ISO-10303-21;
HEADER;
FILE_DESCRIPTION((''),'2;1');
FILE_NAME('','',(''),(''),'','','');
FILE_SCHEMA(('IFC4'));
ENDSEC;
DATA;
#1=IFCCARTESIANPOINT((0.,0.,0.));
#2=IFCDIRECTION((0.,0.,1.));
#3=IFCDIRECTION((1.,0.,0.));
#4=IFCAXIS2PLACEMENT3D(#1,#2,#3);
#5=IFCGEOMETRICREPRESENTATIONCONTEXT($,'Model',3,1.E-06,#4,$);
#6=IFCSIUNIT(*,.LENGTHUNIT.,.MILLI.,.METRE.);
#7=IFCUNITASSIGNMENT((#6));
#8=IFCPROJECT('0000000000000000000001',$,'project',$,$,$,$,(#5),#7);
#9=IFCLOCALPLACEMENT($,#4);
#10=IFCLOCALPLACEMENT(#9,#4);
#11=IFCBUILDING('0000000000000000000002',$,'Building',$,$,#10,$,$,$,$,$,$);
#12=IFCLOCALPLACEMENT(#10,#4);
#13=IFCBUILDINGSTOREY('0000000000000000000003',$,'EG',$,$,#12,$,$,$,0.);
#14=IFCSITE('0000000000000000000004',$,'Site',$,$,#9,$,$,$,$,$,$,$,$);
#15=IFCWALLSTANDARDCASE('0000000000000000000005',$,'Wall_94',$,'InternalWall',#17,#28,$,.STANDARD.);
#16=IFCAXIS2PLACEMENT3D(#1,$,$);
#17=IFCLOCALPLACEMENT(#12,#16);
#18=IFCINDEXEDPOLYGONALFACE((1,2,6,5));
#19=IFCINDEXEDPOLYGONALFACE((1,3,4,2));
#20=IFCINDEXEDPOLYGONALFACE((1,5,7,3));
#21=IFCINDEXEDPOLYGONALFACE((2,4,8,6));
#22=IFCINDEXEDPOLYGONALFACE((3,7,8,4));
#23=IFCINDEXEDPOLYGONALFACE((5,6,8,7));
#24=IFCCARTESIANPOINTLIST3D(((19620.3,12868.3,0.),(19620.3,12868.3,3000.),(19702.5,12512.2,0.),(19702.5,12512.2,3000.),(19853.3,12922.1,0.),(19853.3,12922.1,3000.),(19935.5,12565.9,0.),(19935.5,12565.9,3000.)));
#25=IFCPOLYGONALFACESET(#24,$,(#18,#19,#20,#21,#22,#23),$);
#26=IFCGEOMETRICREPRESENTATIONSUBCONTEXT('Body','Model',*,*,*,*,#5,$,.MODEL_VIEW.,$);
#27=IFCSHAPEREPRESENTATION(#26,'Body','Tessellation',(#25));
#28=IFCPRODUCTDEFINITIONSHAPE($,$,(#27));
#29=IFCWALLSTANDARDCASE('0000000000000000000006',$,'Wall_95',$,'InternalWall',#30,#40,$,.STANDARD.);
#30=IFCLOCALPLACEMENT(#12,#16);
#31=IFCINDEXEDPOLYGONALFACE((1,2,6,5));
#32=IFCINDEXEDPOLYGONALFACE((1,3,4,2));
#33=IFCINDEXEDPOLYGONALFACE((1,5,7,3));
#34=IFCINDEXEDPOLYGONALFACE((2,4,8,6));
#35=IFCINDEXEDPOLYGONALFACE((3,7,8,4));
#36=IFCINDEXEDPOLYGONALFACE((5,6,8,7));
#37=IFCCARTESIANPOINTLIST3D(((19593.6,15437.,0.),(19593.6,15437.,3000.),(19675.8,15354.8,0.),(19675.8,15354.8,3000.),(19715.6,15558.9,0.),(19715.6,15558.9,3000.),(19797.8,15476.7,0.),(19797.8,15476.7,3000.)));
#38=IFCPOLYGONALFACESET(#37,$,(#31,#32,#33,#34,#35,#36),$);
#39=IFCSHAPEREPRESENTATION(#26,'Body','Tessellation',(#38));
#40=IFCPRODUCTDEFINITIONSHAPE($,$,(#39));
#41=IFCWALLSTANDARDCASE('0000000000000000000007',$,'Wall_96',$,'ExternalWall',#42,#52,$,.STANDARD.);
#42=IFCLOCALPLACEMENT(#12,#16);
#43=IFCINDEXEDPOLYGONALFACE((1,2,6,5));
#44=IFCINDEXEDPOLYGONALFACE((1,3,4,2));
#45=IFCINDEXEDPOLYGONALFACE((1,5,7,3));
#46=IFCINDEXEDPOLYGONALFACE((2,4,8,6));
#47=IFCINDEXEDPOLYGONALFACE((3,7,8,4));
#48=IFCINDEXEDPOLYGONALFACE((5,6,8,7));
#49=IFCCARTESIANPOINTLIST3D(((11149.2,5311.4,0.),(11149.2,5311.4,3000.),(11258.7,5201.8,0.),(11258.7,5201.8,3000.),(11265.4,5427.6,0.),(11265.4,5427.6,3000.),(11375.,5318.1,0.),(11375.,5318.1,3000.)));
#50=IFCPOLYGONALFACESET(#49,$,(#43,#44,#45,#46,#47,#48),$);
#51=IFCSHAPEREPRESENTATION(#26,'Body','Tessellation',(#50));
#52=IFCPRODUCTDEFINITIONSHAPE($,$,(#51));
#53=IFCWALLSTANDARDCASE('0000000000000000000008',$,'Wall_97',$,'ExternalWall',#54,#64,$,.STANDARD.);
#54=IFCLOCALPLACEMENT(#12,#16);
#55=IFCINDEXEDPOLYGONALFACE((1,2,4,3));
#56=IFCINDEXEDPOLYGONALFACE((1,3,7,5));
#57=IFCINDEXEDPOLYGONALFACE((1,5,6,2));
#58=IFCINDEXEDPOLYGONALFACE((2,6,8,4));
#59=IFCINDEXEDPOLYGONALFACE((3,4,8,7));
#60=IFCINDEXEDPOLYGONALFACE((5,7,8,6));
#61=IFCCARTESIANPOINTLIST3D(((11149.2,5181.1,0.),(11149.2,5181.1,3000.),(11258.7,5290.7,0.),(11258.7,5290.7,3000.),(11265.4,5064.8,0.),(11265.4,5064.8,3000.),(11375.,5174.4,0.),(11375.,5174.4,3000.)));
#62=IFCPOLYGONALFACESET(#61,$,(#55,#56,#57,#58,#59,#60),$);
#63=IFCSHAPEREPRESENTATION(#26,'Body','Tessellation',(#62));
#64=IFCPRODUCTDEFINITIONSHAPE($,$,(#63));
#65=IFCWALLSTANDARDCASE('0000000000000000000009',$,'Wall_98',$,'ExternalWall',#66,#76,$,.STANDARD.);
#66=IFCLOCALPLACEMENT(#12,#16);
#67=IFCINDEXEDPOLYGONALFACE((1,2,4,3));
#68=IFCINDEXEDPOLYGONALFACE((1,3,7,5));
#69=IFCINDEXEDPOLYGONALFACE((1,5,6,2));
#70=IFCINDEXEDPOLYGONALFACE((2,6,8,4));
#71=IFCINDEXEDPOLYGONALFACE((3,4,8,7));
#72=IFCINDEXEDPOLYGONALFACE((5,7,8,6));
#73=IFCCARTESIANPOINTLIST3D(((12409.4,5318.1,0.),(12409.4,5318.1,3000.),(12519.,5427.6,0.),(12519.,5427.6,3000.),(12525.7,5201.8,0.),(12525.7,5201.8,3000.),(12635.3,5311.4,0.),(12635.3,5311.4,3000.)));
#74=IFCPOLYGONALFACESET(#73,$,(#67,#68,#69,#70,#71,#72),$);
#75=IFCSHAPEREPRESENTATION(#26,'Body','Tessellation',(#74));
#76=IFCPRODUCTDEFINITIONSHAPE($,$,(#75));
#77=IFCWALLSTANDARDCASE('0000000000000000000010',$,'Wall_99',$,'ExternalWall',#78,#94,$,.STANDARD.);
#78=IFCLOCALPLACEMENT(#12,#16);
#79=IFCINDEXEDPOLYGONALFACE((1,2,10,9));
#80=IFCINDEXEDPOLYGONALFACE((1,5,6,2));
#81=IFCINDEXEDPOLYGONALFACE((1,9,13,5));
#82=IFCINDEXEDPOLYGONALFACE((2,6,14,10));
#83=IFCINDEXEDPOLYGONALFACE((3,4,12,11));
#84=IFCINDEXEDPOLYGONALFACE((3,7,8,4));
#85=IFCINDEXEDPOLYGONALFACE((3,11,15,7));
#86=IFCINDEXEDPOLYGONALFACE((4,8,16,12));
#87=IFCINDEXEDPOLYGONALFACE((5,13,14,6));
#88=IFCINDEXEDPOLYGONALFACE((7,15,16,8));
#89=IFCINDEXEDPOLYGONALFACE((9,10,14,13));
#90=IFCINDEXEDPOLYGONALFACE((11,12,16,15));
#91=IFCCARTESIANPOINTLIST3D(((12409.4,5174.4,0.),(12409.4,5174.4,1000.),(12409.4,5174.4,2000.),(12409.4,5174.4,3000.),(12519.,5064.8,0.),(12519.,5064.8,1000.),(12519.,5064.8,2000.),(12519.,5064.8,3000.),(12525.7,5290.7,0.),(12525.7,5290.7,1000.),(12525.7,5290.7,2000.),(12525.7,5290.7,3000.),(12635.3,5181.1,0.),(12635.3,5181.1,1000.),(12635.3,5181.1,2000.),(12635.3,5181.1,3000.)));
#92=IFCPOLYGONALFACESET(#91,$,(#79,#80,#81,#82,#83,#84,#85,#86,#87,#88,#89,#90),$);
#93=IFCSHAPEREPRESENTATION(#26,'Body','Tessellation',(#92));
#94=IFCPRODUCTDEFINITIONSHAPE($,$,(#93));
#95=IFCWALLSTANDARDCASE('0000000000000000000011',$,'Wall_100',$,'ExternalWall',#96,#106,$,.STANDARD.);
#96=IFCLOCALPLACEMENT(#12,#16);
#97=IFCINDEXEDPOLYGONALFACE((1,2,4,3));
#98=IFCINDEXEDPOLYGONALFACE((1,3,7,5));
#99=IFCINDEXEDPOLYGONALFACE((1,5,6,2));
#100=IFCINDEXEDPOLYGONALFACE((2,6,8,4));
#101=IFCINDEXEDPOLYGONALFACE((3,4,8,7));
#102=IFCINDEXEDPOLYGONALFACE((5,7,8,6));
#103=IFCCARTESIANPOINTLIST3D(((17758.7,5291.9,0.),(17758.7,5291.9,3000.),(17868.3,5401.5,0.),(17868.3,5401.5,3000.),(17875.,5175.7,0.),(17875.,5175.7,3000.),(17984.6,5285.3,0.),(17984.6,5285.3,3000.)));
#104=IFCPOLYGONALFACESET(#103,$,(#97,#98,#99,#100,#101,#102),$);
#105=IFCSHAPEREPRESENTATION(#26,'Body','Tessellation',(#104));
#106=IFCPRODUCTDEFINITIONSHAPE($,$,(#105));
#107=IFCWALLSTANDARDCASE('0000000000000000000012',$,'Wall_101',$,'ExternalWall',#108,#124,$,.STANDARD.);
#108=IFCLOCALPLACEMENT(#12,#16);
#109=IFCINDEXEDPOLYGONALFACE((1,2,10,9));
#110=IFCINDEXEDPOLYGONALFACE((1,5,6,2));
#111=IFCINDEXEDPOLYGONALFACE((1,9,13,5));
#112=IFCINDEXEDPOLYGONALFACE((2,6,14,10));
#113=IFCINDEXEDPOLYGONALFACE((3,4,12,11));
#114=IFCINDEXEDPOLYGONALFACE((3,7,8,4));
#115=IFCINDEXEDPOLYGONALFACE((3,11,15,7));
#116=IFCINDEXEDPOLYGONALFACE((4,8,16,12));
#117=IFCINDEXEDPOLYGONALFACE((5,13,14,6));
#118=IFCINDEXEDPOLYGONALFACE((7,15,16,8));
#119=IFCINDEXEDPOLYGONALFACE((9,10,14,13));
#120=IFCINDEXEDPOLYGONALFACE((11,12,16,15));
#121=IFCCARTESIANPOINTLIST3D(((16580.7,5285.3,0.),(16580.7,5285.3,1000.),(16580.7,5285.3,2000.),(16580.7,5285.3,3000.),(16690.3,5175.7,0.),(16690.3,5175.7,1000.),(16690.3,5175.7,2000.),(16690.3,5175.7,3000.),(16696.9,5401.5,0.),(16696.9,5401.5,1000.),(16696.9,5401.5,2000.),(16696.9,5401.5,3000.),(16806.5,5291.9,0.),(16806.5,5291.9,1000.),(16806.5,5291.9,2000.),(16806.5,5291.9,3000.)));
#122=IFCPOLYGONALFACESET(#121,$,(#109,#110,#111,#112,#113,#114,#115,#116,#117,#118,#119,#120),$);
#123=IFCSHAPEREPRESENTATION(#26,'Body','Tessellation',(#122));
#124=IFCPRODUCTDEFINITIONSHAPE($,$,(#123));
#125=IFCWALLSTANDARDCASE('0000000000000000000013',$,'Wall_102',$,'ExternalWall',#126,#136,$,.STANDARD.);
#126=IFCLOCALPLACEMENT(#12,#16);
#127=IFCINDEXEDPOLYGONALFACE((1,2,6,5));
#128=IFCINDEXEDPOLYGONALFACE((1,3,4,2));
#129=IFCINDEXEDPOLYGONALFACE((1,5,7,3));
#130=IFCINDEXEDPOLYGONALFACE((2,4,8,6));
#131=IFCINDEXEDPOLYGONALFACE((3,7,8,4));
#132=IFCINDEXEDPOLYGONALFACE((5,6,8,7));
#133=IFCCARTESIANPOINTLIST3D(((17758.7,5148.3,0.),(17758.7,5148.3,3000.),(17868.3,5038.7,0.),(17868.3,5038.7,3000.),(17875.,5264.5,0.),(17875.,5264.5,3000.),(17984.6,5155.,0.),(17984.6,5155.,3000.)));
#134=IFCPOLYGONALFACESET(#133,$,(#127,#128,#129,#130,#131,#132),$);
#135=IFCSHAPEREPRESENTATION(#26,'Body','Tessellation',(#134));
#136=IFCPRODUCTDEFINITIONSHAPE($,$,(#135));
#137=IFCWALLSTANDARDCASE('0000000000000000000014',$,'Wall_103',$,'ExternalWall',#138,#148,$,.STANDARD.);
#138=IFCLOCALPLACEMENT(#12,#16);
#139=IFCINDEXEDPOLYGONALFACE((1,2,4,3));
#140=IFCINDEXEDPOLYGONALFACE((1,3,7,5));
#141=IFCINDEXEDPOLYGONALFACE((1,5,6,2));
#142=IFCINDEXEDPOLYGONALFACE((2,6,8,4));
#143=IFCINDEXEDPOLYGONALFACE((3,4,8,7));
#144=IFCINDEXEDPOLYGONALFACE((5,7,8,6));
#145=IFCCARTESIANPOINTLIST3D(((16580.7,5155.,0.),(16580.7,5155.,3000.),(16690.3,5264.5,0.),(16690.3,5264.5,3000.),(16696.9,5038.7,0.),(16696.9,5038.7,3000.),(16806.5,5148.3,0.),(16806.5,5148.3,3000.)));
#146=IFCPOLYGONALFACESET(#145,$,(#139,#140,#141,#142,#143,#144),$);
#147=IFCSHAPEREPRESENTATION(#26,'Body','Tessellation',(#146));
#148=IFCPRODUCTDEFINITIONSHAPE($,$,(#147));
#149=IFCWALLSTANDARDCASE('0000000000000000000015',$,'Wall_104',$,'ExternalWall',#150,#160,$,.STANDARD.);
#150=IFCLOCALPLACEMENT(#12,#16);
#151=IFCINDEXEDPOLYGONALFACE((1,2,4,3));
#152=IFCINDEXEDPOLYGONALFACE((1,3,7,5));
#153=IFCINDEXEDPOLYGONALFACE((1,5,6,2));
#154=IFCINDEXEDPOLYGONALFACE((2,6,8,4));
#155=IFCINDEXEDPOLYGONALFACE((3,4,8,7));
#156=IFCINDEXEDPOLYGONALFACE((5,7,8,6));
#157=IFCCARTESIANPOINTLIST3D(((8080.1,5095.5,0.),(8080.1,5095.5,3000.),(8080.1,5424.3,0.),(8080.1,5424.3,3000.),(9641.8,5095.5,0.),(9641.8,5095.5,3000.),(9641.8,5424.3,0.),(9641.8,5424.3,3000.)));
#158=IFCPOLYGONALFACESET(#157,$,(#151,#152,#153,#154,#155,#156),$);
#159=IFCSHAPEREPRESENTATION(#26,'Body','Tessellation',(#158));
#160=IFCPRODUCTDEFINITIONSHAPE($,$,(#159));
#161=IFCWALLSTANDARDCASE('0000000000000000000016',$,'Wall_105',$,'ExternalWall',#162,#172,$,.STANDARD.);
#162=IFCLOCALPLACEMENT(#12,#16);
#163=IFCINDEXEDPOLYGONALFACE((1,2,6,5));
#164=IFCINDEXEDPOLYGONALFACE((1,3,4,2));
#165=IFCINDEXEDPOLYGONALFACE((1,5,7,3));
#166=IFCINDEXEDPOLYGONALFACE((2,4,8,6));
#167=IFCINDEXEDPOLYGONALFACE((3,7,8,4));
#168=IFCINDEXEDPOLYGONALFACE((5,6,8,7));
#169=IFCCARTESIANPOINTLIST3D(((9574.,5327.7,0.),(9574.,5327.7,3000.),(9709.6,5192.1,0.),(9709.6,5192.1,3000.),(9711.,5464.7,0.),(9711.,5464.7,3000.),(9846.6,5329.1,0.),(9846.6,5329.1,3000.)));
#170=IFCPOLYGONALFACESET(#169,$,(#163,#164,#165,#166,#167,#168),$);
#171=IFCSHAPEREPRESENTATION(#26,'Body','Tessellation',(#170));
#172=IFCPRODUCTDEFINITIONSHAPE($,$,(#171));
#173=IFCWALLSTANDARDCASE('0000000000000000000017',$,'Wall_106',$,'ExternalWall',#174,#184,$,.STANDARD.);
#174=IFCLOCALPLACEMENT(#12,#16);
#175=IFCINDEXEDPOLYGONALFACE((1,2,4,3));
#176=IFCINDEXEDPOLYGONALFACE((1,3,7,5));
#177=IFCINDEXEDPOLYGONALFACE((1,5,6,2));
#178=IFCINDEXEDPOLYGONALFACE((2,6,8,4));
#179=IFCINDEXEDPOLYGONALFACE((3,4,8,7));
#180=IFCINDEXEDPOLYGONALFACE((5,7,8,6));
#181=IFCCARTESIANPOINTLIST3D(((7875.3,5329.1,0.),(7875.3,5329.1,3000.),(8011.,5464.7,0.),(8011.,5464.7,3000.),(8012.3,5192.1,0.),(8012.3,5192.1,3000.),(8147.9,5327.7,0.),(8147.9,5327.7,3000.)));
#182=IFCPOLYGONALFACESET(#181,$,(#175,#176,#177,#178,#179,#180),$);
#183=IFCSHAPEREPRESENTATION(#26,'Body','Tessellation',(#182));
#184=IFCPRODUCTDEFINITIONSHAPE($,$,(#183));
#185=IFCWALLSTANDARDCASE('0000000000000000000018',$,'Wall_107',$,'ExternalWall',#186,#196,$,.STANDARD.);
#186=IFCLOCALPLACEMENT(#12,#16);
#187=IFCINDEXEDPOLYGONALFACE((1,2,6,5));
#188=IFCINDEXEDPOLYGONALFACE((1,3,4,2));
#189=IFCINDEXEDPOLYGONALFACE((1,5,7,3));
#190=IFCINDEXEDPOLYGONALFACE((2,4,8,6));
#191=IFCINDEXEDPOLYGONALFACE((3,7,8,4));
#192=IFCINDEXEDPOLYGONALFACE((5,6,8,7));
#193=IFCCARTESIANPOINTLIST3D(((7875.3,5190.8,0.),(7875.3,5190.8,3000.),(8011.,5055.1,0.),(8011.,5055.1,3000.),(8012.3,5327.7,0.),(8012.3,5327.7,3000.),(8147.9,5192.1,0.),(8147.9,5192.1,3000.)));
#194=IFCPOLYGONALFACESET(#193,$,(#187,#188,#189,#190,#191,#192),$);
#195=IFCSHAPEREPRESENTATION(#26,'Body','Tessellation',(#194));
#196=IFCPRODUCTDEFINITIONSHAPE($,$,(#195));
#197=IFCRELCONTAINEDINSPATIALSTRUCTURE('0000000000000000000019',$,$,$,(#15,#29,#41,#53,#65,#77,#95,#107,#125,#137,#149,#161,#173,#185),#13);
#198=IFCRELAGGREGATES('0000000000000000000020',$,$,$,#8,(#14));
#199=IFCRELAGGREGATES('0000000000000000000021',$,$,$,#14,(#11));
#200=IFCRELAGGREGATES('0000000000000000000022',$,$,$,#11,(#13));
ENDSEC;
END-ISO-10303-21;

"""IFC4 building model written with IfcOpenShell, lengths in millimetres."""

from ifc_helpers import new_model, si_unit, frame, origin_with_axes, place, context, subcontext, project, spatial, rectangle, extrude, element, save


model = new_model("IFC4")

# Units and contexts
model_context = context("Model", 3, precision=1e-06, world=origin_with_axes())
body_context = subcontext(model_context, "Body", "Model", "MODEL_VIEW")
ifc_project = project(units=[si_unit("LENGTHUNIT", "METRE", prefix="MILLI")], contexts=[model_context])

# Site, building, storey
site_placement = place(None, origin_with_axes())
site = spatial("IfcSite", under=ifc_project, at=site_placement, Name="Site")
building_placement = place(site_placement, origin_with_axes())
building = spatial("IfcBuilding", under=site, at=building_placement, Name="Building")
storey_placement = place(building_placement, origin_with_axes())
storey = spatial("IfcBuildingStorey", under=building, at=storey_placement, Name="EG", Elevation=0.0)

# Walls
wall_1_placement = place(storey_placement, origin_with_axes())
element("IfcWallStandardCase", 1, at=wall_1_placement, inside=storey, Name="Wall_94", ObjectType="InternalWall", PredefinedType="STANDARD", context=body_context, shape_type="SweptSolid", body=[
    extrude(rectangle(XDim=365.5, YDim=239.1), frame((19777.9, 12717.1, 0.0), z_axis=(0.0, 0.0, 1.0), x_axis=(0.22486, -0.974391, 0.0)), (0.0, 0.0, 1.0), 3000.0),
])
wall_2_placement = place(storey_placement, origin_with_axes())
element("IfcWallStandardCase", 2, at=wall_2_placement, inside=storey, Name="Wall_95", ObjectType="InternalWall", PredefinedType="STANDARD", context=body_context, shape_type="SweptSolid", body=[
    extrude(rectangle(XDim=116.2, YDim=172.5), frame((19695.7, 15456.9, 0.0), z_axis=(0.0, 0.0, 1.0), x_axis=(-0.707107, 0.707107, 0.0)), (0.0, 0.0, 1.0), 3000.0),
])
wall_3_placement = place(storey_placement, origin_with_axes())
element("IfcWallStandardCase", 3, at=wall_3_placement, inside=storey, Name="Wall_96", ObjectType="ExternalWall", PredefinedType="STANDARD", context=body_context, shape_type="SweptSolid", body=[
    extrude(rectangle(XDim=155.0, YDim=164.4), frame((11262.1, 5314.7, 0.0), z_axis=(0.0, 0.0, 1.0), x_axis=(-0.707107, 0.707107, 0.0)), (0.0, 0.0, 1.0), 3000.0),
])
wall_4_placement = place(storey_placement, origin_with_axes())
element("IfcWallStandardCase", 4, at=wall_4_placement, inside=storey, Name="Wall_97", ObjectType="ExternalWall", PredefinedType="STANDARD", context=body_context, shape_type="SweptSolid", body=[
    extrude(rectangle(XDim=155.0, YDim=164.4), frame((11262.1, 5177.7, 0.0), z_axis=(0.0, 0.0, 1.0), x_axis=(-0.707107, -0.707107, 0.0)), (0.0, 0.0, 1.0), 3000.0),
])
wall_5_placement = place(storey_placement, origin_with_axes())
element("IfcWallStandardCase", 5, at=wall_5_placement, inside=storey, Name="Wall_98", ObjectType="ExternalWall", PredefinedType="STANDARD", context=body_context, shape_type="SweptSolid", body=[
    extrude(rectangle(XDim=155.0, YDim=164.4), frame((12522.3, 5314.7, 0.0), z_axis=(0.0, 0.0, 1.0), x_axis=(0.707107, 0.707107, 0.0)), (0.0, 0.0, 1.0), 3000.0),
])

# Wall, opening
wall_6_placement = place(storey_placement, origin_with_axes())
wall_6 = element("IfcWallStandardCase", 6, at=wall_6_placement, inside=storey, Name="Wall_99", ObjectType="ExternalWall", PredefinedType="STANDARD", context=body_context, shape_type="SweptSolid", body=[
    extrude(rectangle(XDim=155.0, YDim=164.4), frame((12522.3, 5177.7, 0.0), z_axis=(0.0, 0.0, 1.0), x_axis=(0.707107, -0.707107, 0.0)), (0.0, 0.0, 1.0), 3000.0),
])
opening_1_placement = place(wall_6_placement, origin_with_axes())
element("IfcOpeningElement", 7, at=opening_1_placement, inside=storey, cuts=wall_6, context=body_context, shape_type="SweptSolid", body=[
    extrude(rectangle(XDim=600.0, YDim=164.4), frame((12522.3, 5177.7, 1000.0), z_axis=(0.0, 0.0, 1.0), x_axis=(0.707107, -0.707107, 0.0)), (0.0, 0.0, 1.0), 1000.0),
])

# Wall
wall_7_placement = place(storey_placement, origin_with_axes())
element("IfcWallStandardCase", 8, at=wall_7_placement, inside=storey, Name="Wall_100", ObjectType="ExternalWall", PredefinedType="STANDARD", context=body_context, shape_type="SweptSolid", body=[
    extrude(rectangle(XDim=155.0, YDim=164.4), frame((17871.7, 5288.6, 0.0), z_axis=(0.0, 0.0, 1.0), x_axis=(0.707107, 0.707107, 0.0)), (0.0, 0.0, 1.0), 3000.0),
])

# Wall, opening
wall_8_placement = place(storey_placement, origin_with_axes())
wall_8 = element("IfcWallStandardCase", 9, at=wall_8_placement, inside=storey, Name="Wall_101", ObjectType="ExternalWall", PredefinedType="STANDARD", context=body_context, shape_type="SweptSolid", body=[
    extrude(rectangle(XDim=155.0, YDim=164.4), frame((16693.6, 5288.6, 0.0), z_axis=(0.0, 0.0, 1.0), x_axis=(-0.707107, 0.707107, 0.0)), (0.0, 0.0, 1.0), 3000.0),
])
opening_2_placement = place(wall_8_placement, origin_with_axes())
element("IfcOpeningElement", 10, at=opening_2_placement, inside=storey, cuts=wall_8, context=body_context, shape_type="SweptSolid", body=[
    extrude(rectangle(XDim=600.0, YDim=164.4), frame((16693.6, 5288.6, 1000.0), z_axis=(0.0, 0.0, 1.0), x_axis=(-0.707107, 0.707107, 0.0)), (0.0, 0.0, 1.0), 1000.0),
])

# Walls
wall_9_placement = place(storey_placement, origin_with_axes())
element("IfcWallStandardCase", 11, at=wall_9_placement, inside=storey, Name="Wall_102", ObjectType="ExternalWall", PredefinedType="STANDARD", context=body_context, shape_type="SweptSolid", body=[
    extrude(rectangle(XDim=155.0, YDim=164.4), frame((17871.7, 5151.6, 0.0), z_axis=(0.0, 0.0, 1.0), x_axis=(0.707107, -0.707107, 0.0)), (0.0, 0.0, 1.0), 3000.0),
])
wall_10_placement = place(storey_placement, origin_with_axes())
element("IfcWallStandardCase", 12, at=wall_10_placement, inside=storey, Name="Wall_103", ObjectType="ExternalWall", PredefinedType="STANDARD", context=body_context, shape_type="SweptSolid", body=[
    extrude(rectangle(XDim=155.0, YDim=164.4), frame((16693.6, 5151.6, 0.0), z_axis=(0.0, 0.0, 1.0), x_axis=(-0.707107, -0.707107, 0.0)), (0.0, 0.0, 1.0), 3000.0),
])
wall_11_placement = place(storey_placement, origin_with_axes())
element("IfcWallStandardCase", 13, at=wall_11_placement, inside=storey, Name="Wall_104", ObjectType="ExternalWall", PredefinedType="STANDARD", context=body_context, shape_type="SweptSolid", body=[
    extrude(rectangle(XDim=1561.6, YDim=328.8), frame((8861.0, 5259.9, 0.0), z_axis=(0.0, 0.0, 1.0), x_axis=(-1.0, 0.0, 0.0)), (0.0, 0.0, 1.0), 3000.0),
])
wall_12_placement = place(storey_placement, origin_with_axes())
element("IfcWallStandardCase", 14, at=wall_12_placement, inside=storey, Name="Wall_105", ObjectType="ExternalWall", PredefinedType="STANDARD", context=body_context, shape_type="SweptSolid", body=[
    extrude(rectangle(XDim=193.7, YDim=191.8), frame((9710.3, 5328.4, 0.0), z_axis=(0.0, 0.0, 1.0), x_axis=(0.707107, 0.707107, 0.0)), (0.0, 0.0, 1.0), 3000.0),
])
wall_13_placement = place(storey_placement, origin_with_axes())
element("IfcWallStandardCase", 15, at=wall_13_placement, inside=storey, Name="Wall_106", ObjectType="ExternalWall", PredefinedType="STANDARD", context=body_context, shape_type="SweptSolid", body=[
    extrude(rectangle(XDim=193.7, YDim=191.8), frame((8011.6, 5328.4, 0.0), z_axis=(0.0, 0.0, 1.0), x_axis=(-0.707107, 0.707107, 0.0)), (0.0, 0.0, 1.0), 3000.0),
])
wall_14_placement = place(storey_placement, origin_with_axes())
element("IfcWallStandardCase", 16, at=wall_14_placement, inside=storey, Name="Wall_107", ObjectType="ExternalWall", PredefinedType="STANDARD", context=body_context, shape_type="SweptSolid", body=[
    extrude(rectangle(XDim=193.7, YDim=191.8), frame((8011.6, 5191.4, 0.0), z_axis=(0.0, 0.0, 1.0), x_axis=(-0.707107, -0.707107, 0.0)), (0.0, 0.0, 1.0), 3000.0),
])

save(model, "model.ifc")
